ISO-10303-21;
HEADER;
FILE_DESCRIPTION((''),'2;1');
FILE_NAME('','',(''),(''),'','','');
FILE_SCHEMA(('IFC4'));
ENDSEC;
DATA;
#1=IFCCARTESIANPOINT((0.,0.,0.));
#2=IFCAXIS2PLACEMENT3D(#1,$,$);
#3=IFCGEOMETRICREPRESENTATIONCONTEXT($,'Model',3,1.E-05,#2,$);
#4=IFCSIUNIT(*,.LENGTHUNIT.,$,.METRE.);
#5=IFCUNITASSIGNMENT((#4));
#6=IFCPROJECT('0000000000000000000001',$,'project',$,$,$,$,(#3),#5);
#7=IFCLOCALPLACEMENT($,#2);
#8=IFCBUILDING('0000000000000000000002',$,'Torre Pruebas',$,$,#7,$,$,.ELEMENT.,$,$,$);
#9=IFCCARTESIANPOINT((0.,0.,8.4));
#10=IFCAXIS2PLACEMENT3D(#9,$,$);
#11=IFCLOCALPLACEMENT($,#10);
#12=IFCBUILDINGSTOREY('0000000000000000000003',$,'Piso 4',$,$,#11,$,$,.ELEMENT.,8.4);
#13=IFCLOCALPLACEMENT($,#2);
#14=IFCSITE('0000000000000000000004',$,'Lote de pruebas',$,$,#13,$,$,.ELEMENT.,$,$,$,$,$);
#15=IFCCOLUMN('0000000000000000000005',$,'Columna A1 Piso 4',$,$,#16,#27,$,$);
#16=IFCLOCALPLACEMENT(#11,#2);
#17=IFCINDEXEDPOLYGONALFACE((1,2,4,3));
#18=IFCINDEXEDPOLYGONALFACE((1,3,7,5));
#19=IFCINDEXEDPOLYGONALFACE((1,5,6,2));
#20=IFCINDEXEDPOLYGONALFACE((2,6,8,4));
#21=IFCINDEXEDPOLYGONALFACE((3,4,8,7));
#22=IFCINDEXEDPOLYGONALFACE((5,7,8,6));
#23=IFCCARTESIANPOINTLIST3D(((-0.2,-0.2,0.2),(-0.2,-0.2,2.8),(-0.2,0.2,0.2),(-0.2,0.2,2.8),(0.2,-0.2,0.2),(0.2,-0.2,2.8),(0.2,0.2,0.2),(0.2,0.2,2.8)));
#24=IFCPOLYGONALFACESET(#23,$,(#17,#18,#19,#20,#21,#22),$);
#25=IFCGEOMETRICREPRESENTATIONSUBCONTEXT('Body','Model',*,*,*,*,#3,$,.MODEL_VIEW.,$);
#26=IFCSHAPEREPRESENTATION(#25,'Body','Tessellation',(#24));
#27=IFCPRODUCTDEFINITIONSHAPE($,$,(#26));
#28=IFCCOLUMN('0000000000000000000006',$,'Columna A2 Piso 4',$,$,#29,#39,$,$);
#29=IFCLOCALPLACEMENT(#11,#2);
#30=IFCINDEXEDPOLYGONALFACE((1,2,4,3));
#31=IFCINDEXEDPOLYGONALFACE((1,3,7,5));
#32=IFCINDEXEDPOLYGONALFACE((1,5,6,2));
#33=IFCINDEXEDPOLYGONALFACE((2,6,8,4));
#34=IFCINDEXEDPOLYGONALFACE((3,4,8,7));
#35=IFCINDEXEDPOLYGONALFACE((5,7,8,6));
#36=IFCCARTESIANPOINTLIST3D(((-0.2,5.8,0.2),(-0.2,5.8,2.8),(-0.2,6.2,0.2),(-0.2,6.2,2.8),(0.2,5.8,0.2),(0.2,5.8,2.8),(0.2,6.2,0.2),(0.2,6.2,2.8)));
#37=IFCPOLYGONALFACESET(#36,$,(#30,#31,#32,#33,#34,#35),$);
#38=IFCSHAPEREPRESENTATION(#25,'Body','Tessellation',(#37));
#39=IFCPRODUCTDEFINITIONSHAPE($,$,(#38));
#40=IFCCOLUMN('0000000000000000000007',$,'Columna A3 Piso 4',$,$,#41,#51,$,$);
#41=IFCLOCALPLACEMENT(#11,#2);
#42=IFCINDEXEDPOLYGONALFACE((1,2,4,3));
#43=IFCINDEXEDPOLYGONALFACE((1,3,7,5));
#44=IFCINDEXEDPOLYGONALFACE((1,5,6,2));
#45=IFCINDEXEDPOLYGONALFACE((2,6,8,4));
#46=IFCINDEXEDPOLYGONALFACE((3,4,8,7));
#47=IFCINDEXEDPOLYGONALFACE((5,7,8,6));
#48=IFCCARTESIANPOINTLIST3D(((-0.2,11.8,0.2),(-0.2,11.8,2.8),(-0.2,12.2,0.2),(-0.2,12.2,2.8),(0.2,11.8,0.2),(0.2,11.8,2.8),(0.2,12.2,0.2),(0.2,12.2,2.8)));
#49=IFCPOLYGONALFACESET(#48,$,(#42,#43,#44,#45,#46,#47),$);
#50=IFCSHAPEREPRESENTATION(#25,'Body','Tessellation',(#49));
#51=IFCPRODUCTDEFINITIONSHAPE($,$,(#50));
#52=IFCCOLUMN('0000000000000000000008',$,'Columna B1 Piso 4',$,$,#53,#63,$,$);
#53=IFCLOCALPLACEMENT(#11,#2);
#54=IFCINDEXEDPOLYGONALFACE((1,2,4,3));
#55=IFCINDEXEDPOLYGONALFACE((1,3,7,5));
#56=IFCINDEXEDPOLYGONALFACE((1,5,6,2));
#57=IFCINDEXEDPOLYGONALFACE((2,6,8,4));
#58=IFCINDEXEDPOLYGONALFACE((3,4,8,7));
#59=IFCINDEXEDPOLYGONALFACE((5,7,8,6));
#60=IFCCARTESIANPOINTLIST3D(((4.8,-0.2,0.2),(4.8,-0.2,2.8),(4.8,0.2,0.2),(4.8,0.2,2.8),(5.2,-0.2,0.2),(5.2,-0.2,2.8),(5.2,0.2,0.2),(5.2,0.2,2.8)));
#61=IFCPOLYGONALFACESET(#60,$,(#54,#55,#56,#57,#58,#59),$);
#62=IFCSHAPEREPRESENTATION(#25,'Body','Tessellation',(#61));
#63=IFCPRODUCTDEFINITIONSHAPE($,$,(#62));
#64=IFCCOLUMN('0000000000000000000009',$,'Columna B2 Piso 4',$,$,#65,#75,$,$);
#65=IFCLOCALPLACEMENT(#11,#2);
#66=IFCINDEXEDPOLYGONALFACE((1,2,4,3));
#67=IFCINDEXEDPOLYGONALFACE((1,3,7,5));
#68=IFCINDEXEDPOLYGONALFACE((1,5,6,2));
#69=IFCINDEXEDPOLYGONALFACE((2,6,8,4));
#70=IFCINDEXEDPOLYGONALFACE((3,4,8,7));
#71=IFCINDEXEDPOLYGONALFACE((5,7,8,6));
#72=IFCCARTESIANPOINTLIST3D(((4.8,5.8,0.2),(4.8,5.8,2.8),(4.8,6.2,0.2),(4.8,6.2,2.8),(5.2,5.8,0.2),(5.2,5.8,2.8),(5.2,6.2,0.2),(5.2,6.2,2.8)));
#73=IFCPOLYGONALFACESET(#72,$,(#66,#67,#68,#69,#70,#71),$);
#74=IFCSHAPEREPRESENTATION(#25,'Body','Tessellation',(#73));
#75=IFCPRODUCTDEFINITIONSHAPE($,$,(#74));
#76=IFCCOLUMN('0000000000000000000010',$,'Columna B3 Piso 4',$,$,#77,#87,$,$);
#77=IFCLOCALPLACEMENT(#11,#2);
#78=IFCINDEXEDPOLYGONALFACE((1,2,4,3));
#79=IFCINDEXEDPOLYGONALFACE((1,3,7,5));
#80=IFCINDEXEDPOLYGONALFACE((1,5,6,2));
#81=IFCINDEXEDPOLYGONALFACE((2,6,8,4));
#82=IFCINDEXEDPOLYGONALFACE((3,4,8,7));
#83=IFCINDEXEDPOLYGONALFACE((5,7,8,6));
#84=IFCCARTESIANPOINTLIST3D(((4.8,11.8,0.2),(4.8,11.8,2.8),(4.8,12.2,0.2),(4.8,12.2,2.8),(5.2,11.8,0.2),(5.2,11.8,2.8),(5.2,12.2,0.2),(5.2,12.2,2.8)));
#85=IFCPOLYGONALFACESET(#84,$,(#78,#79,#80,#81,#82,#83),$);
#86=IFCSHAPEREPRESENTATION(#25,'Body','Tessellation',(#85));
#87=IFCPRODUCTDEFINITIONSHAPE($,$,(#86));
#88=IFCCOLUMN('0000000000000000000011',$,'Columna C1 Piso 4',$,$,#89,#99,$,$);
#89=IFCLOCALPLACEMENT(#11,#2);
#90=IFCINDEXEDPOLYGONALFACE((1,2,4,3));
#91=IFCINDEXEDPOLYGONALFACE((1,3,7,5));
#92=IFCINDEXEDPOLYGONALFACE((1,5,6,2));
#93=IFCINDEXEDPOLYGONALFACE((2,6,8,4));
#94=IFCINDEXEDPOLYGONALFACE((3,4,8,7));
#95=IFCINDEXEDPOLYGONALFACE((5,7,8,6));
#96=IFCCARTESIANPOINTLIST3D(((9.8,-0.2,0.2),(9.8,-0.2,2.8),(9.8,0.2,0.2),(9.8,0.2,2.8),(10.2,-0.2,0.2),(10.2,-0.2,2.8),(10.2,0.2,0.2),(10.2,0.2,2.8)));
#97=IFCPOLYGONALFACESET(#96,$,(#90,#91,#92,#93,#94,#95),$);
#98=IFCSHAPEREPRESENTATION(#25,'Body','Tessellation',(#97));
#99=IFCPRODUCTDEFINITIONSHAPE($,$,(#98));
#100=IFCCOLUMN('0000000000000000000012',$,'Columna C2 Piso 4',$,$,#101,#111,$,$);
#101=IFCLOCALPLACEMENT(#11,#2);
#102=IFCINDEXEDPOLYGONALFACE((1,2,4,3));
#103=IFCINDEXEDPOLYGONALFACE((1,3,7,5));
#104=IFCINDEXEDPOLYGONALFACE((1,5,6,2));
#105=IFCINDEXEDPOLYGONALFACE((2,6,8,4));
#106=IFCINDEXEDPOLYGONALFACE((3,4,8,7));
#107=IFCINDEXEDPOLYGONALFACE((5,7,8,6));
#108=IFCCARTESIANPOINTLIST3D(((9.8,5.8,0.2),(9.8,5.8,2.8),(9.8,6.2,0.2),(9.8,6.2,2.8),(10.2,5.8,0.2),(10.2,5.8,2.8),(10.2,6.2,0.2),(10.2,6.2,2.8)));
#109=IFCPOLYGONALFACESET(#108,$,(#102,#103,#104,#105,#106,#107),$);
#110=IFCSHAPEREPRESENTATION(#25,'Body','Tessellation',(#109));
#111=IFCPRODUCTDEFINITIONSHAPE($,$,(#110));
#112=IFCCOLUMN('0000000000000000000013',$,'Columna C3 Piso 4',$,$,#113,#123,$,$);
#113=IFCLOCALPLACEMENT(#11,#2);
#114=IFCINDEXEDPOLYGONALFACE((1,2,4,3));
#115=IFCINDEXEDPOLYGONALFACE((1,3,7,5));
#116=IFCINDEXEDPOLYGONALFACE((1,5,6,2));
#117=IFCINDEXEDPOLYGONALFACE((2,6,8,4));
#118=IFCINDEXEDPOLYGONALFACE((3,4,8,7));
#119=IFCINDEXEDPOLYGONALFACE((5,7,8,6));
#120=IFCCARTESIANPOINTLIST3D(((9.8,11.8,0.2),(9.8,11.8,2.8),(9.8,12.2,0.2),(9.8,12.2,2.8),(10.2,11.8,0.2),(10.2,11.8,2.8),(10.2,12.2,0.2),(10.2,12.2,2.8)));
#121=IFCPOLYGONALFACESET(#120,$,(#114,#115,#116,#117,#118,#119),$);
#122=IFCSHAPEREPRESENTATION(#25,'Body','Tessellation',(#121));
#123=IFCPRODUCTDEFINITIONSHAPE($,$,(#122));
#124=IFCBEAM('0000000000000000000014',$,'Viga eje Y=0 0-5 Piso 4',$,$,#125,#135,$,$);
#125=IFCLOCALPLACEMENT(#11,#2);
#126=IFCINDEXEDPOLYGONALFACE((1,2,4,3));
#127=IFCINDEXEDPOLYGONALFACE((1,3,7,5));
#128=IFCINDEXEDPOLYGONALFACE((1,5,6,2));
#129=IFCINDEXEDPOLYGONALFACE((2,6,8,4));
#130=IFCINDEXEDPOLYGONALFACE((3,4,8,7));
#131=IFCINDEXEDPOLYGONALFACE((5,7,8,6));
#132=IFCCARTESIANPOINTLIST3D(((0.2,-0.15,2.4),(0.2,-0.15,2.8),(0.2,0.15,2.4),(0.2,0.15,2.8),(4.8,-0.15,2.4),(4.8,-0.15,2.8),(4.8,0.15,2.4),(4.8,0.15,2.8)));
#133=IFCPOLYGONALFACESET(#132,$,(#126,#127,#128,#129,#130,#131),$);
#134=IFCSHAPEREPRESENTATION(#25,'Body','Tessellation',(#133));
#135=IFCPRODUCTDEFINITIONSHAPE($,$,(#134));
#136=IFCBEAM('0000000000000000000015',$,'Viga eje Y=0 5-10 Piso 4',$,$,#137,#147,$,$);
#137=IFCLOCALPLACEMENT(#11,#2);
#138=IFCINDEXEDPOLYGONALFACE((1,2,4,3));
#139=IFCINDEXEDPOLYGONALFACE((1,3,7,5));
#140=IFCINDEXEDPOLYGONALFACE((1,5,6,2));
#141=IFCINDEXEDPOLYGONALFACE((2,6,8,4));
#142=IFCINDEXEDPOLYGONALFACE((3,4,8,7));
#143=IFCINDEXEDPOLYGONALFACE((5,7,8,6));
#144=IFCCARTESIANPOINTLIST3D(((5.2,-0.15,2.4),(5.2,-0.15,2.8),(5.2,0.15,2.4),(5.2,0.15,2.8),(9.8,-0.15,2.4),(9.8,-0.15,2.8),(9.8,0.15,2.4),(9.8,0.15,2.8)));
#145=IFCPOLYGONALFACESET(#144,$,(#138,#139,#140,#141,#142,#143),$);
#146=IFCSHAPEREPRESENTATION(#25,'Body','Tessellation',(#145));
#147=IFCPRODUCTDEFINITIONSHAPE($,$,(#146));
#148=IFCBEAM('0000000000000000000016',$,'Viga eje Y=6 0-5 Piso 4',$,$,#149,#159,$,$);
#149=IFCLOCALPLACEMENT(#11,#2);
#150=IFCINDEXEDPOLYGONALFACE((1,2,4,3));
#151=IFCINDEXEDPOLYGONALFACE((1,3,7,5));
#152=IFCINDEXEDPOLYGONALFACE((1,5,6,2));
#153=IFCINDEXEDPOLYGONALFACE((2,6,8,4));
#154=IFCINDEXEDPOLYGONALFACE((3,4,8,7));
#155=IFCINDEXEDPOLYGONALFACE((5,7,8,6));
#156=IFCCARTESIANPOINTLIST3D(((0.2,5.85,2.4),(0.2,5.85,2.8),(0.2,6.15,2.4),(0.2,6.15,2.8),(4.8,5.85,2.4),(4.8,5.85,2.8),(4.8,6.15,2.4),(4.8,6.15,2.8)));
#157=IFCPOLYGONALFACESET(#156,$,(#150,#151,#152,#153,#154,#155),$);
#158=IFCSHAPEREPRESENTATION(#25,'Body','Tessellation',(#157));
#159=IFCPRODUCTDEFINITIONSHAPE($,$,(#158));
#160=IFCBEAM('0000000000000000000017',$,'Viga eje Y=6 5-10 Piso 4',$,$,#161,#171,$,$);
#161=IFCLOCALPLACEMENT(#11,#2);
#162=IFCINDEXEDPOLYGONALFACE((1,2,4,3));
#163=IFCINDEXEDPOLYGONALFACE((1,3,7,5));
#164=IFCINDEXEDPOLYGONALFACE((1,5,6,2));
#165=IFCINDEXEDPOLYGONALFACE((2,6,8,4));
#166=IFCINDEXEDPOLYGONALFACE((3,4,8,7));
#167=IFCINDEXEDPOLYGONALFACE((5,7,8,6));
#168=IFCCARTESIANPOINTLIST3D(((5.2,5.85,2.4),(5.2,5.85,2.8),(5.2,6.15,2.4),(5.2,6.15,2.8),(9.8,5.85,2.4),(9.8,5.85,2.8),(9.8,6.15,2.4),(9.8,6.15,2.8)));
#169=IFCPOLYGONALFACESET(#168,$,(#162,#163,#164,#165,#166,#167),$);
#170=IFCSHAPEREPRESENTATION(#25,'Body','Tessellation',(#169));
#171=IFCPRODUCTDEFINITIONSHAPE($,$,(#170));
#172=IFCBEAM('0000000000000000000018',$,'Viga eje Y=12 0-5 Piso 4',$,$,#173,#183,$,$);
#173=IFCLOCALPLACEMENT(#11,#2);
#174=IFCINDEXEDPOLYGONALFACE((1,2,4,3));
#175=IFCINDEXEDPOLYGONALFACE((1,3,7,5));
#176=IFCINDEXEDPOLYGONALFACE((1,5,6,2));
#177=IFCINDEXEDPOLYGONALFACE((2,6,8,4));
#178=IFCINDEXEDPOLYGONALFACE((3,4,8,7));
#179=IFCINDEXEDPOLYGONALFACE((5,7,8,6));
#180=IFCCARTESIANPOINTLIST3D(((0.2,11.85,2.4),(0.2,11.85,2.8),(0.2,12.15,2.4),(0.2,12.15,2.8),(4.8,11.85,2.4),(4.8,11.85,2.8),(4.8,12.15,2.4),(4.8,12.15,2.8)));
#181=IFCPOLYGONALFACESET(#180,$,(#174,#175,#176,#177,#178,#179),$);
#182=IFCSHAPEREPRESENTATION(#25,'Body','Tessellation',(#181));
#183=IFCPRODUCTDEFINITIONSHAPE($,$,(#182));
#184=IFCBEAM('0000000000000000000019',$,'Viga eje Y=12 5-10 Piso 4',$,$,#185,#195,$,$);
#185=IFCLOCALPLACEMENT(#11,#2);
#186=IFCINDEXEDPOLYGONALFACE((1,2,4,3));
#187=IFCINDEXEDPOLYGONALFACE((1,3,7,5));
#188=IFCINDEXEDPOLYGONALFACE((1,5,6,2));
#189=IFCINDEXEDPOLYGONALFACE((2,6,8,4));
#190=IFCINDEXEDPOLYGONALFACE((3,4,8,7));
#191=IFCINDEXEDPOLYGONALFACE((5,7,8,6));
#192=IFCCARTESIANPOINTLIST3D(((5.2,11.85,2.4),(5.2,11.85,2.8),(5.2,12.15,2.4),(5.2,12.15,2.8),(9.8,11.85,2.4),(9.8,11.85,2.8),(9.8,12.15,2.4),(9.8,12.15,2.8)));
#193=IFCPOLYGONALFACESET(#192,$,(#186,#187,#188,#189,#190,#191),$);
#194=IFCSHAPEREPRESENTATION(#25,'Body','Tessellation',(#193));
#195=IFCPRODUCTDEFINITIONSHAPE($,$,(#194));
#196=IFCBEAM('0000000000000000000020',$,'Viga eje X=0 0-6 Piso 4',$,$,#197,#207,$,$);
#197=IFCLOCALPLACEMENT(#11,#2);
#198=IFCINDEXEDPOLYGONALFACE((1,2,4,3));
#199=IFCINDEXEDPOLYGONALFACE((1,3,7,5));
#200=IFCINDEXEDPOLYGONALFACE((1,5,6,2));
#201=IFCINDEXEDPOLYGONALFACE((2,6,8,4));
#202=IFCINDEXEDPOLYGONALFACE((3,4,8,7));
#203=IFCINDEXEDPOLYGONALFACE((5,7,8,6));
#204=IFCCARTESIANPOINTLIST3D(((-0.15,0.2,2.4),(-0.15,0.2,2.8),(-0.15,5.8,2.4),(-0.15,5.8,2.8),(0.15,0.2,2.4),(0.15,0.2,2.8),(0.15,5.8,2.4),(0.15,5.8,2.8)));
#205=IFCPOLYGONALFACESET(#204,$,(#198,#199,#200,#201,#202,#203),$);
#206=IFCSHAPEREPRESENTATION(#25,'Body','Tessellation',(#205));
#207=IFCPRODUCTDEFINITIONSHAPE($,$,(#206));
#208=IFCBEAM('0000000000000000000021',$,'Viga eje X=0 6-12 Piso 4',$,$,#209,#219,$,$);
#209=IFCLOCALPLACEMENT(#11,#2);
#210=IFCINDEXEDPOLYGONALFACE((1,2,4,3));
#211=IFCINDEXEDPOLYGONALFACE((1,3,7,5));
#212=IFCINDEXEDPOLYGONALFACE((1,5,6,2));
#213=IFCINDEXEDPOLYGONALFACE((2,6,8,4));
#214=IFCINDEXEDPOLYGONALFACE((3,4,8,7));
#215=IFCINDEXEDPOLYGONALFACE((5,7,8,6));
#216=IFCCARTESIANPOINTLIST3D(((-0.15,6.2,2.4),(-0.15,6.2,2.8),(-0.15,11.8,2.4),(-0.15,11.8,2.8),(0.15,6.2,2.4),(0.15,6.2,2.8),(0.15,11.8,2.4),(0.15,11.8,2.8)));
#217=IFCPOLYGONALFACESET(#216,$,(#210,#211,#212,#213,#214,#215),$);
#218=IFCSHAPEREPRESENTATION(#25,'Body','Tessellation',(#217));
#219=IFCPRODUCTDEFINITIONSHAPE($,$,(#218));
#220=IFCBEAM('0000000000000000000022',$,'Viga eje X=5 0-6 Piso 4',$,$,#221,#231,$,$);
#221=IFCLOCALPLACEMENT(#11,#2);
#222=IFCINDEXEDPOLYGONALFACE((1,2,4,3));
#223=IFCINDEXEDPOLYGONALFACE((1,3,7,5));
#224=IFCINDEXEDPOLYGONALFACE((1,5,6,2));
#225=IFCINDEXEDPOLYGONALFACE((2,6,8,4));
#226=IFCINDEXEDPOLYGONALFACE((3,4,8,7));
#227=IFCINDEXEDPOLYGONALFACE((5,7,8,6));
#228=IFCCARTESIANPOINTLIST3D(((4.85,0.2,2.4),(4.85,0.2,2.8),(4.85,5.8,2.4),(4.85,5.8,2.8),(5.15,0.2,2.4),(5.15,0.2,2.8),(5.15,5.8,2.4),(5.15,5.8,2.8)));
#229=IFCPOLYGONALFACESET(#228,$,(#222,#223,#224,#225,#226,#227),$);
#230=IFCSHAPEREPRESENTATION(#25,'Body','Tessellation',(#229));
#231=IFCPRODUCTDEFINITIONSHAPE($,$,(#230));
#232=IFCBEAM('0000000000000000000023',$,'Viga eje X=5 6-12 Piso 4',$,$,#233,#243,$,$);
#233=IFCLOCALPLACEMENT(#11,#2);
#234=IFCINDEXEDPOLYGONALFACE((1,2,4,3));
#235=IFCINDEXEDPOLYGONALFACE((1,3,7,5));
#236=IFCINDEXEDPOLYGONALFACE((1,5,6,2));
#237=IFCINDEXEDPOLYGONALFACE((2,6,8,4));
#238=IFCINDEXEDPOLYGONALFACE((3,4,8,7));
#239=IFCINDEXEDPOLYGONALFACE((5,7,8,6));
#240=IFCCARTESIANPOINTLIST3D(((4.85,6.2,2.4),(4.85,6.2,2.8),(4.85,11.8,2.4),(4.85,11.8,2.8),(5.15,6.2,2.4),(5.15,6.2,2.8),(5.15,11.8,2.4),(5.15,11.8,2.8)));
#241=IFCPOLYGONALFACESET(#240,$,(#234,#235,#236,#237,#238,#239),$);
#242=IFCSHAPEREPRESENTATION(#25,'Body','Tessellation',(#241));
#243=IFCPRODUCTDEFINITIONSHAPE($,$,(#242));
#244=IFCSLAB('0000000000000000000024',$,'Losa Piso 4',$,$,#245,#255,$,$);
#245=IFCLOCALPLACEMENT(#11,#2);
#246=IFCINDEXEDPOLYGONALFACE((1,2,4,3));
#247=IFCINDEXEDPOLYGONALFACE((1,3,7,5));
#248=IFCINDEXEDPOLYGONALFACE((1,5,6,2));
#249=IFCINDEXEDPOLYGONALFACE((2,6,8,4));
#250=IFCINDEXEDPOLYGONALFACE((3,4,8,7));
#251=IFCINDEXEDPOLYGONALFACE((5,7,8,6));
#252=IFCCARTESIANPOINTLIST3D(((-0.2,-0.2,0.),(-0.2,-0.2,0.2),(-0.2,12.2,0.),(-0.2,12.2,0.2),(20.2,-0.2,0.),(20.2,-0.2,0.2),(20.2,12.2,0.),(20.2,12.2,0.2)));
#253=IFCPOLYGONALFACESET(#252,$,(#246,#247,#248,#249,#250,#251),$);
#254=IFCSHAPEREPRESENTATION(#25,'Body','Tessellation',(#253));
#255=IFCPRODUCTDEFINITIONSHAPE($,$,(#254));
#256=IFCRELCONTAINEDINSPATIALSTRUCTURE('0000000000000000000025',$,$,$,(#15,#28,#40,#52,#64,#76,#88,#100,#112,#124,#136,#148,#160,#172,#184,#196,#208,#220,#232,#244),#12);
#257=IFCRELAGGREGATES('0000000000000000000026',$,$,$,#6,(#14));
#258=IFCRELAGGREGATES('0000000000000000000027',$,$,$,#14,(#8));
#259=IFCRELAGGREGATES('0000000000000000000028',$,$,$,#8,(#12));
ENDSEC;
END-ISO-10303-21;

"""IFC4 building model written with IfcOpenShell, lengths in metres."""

from ifc_helpers import new_model, si_unit, frame, origin, origin_2d, place, context, subcontext, project, spatial, rectangle, extrude, element, save


model = new_model("IFC4")

# Units and contexts
model_context = context("Model", 3, precision=1e-05, world=origin())
body_context = subcontext(model_context, "Body", "Model", "MODEL_VIEW")
ifc_project = project(units=[si_unit("LENGTHUNIT", "METRE")], contexts=[model_context])

# Site, building, storey
site_placement = place(None, origin())
site = spatial("IfcSite", under=ifc_project, at=site_placement, Name="Lote de pruebas", CompositionType="ELEMENT")
building_placement = place(None, origin())
building = spatial("IfcBuilding", under=site, at=building_placement, Name="Torre Pruebas", CompositionType="ELEMENT")
storey_placement = place(None, frame((0.0, 0.0, 8.4)))
storey = spatial("IfcBuildingStorey", under=building, at=storey_placement, Name="Piso 4", CompositionType="ELEMENT", Elevation=8.4)

# Columns
for number, where, name in (
    (1, (0.0, 0.0, 8.6), "Columna A1 Piso 4"),
    (2, (0.0, 6.0, 8.6), "Columna A2 Piso 4"),
    (3, (0.0, 12.0, 8.6), "Columna A3 Piso 4"),
    (4, (5.0, 0.0, 8.6), "Columna B1 Piso 4"),
    (5, (5.0, 6.0, 8.6), "Columna B2 Piso 4"),
    (6, (5.0, 12.0, 8.6), "Columna B3 Piso 4"),
    (7, (10.0, 0.0, 8.6), "Columna C1 Piso 4"),
    (8, (10.0, 6.0, 8.6), "Columna C2 Piso 4"),
    (9, (10.0, 12.0, 8.6), "Columna C3 Piso 4"),
):
    element("IfcColumn", number, at=place(None, frame(where)), inside=storey, Name=name, context=body_context, shape_type="SweptSolid", body=[
        extrude(rectangle(XDim=0.4, YDim=0.4, at=origin_2d()), origin(), (0.0, 0.0, 1.0), 2.6),
    ])

# Beams
for number, where, name in (
    (10, (2.5, 0.0, 10.8), "Viga eje Y=0 0-5 Piso 4"),
    (11, (7.5, 0.0, 10.8), "Viga eje Y=0 5-10 Piso 4"),
    (12, (2.5, 6.0, 10.8), "Viga eje Y=6 0-5 Piso 4"),
    (13, (7.5, 6.0, 10.8), "Viga eje Y=6 5-10 Piso 4"),
    (14, (2.5, 12.0, 10.8), "Viga eje Y=12 0-5 Piso 4"),
    (15, (7.5, 12.0, 10.8), "Viga eje Y=12 5-10 Piso 4"),
):
    element("IfcBeam", number, at=place(None, frame(where)), inside=storey, Name=name, context=body_context, shape_type="SweptSolid", body=[
        extrude(rectangle(XDim=4.6, YDim=0.3, at=origin_2d()), origin(), (0.0, 0.0, 1.0), 0.4),
    ])
for number, where, name in (
    (16, (0.0, 3.0, 10.8), "Viga eje X=0 0-6 Piso 4"),
    (17, (0.0, 9.0, 10.8), "Viga eje X=0 6-12 Piso 4"),
    (18, (5.0, 3.0, 10.8), "Viga eje X=5 0-6 Piso 4"),
    (19, (5.0, 9.0, 10.8), "Viga eje X=5 6-12 Piso 4"),
):
    element("IfcBeam", number, at=place(None, frame(where)), inside=storey, Name=name, context=body_context, shape_type="SweptSolid", body=[
        extrude(rectangle(XDim=0.3, YDim=5.6, at=origin_2d()), origin(), (0.0, 0.0, 1.0), 0.4),
    ])

# Slab
slab_placement = place(None, frame((10.0, 6.0, 8.4)))
element("IfcSlab", 20, at=slab_placement, inside=storey, Name="Losa Piso 4", context=body_context, shape_type="SweptSolid", body=[
    extrude(rectangle(XDim=20.4, YDim=12.4, at=origin_2d()), origin(), (0.0, 0.0, 1.0), 0.2),
])

save(model, "model.ifc")
